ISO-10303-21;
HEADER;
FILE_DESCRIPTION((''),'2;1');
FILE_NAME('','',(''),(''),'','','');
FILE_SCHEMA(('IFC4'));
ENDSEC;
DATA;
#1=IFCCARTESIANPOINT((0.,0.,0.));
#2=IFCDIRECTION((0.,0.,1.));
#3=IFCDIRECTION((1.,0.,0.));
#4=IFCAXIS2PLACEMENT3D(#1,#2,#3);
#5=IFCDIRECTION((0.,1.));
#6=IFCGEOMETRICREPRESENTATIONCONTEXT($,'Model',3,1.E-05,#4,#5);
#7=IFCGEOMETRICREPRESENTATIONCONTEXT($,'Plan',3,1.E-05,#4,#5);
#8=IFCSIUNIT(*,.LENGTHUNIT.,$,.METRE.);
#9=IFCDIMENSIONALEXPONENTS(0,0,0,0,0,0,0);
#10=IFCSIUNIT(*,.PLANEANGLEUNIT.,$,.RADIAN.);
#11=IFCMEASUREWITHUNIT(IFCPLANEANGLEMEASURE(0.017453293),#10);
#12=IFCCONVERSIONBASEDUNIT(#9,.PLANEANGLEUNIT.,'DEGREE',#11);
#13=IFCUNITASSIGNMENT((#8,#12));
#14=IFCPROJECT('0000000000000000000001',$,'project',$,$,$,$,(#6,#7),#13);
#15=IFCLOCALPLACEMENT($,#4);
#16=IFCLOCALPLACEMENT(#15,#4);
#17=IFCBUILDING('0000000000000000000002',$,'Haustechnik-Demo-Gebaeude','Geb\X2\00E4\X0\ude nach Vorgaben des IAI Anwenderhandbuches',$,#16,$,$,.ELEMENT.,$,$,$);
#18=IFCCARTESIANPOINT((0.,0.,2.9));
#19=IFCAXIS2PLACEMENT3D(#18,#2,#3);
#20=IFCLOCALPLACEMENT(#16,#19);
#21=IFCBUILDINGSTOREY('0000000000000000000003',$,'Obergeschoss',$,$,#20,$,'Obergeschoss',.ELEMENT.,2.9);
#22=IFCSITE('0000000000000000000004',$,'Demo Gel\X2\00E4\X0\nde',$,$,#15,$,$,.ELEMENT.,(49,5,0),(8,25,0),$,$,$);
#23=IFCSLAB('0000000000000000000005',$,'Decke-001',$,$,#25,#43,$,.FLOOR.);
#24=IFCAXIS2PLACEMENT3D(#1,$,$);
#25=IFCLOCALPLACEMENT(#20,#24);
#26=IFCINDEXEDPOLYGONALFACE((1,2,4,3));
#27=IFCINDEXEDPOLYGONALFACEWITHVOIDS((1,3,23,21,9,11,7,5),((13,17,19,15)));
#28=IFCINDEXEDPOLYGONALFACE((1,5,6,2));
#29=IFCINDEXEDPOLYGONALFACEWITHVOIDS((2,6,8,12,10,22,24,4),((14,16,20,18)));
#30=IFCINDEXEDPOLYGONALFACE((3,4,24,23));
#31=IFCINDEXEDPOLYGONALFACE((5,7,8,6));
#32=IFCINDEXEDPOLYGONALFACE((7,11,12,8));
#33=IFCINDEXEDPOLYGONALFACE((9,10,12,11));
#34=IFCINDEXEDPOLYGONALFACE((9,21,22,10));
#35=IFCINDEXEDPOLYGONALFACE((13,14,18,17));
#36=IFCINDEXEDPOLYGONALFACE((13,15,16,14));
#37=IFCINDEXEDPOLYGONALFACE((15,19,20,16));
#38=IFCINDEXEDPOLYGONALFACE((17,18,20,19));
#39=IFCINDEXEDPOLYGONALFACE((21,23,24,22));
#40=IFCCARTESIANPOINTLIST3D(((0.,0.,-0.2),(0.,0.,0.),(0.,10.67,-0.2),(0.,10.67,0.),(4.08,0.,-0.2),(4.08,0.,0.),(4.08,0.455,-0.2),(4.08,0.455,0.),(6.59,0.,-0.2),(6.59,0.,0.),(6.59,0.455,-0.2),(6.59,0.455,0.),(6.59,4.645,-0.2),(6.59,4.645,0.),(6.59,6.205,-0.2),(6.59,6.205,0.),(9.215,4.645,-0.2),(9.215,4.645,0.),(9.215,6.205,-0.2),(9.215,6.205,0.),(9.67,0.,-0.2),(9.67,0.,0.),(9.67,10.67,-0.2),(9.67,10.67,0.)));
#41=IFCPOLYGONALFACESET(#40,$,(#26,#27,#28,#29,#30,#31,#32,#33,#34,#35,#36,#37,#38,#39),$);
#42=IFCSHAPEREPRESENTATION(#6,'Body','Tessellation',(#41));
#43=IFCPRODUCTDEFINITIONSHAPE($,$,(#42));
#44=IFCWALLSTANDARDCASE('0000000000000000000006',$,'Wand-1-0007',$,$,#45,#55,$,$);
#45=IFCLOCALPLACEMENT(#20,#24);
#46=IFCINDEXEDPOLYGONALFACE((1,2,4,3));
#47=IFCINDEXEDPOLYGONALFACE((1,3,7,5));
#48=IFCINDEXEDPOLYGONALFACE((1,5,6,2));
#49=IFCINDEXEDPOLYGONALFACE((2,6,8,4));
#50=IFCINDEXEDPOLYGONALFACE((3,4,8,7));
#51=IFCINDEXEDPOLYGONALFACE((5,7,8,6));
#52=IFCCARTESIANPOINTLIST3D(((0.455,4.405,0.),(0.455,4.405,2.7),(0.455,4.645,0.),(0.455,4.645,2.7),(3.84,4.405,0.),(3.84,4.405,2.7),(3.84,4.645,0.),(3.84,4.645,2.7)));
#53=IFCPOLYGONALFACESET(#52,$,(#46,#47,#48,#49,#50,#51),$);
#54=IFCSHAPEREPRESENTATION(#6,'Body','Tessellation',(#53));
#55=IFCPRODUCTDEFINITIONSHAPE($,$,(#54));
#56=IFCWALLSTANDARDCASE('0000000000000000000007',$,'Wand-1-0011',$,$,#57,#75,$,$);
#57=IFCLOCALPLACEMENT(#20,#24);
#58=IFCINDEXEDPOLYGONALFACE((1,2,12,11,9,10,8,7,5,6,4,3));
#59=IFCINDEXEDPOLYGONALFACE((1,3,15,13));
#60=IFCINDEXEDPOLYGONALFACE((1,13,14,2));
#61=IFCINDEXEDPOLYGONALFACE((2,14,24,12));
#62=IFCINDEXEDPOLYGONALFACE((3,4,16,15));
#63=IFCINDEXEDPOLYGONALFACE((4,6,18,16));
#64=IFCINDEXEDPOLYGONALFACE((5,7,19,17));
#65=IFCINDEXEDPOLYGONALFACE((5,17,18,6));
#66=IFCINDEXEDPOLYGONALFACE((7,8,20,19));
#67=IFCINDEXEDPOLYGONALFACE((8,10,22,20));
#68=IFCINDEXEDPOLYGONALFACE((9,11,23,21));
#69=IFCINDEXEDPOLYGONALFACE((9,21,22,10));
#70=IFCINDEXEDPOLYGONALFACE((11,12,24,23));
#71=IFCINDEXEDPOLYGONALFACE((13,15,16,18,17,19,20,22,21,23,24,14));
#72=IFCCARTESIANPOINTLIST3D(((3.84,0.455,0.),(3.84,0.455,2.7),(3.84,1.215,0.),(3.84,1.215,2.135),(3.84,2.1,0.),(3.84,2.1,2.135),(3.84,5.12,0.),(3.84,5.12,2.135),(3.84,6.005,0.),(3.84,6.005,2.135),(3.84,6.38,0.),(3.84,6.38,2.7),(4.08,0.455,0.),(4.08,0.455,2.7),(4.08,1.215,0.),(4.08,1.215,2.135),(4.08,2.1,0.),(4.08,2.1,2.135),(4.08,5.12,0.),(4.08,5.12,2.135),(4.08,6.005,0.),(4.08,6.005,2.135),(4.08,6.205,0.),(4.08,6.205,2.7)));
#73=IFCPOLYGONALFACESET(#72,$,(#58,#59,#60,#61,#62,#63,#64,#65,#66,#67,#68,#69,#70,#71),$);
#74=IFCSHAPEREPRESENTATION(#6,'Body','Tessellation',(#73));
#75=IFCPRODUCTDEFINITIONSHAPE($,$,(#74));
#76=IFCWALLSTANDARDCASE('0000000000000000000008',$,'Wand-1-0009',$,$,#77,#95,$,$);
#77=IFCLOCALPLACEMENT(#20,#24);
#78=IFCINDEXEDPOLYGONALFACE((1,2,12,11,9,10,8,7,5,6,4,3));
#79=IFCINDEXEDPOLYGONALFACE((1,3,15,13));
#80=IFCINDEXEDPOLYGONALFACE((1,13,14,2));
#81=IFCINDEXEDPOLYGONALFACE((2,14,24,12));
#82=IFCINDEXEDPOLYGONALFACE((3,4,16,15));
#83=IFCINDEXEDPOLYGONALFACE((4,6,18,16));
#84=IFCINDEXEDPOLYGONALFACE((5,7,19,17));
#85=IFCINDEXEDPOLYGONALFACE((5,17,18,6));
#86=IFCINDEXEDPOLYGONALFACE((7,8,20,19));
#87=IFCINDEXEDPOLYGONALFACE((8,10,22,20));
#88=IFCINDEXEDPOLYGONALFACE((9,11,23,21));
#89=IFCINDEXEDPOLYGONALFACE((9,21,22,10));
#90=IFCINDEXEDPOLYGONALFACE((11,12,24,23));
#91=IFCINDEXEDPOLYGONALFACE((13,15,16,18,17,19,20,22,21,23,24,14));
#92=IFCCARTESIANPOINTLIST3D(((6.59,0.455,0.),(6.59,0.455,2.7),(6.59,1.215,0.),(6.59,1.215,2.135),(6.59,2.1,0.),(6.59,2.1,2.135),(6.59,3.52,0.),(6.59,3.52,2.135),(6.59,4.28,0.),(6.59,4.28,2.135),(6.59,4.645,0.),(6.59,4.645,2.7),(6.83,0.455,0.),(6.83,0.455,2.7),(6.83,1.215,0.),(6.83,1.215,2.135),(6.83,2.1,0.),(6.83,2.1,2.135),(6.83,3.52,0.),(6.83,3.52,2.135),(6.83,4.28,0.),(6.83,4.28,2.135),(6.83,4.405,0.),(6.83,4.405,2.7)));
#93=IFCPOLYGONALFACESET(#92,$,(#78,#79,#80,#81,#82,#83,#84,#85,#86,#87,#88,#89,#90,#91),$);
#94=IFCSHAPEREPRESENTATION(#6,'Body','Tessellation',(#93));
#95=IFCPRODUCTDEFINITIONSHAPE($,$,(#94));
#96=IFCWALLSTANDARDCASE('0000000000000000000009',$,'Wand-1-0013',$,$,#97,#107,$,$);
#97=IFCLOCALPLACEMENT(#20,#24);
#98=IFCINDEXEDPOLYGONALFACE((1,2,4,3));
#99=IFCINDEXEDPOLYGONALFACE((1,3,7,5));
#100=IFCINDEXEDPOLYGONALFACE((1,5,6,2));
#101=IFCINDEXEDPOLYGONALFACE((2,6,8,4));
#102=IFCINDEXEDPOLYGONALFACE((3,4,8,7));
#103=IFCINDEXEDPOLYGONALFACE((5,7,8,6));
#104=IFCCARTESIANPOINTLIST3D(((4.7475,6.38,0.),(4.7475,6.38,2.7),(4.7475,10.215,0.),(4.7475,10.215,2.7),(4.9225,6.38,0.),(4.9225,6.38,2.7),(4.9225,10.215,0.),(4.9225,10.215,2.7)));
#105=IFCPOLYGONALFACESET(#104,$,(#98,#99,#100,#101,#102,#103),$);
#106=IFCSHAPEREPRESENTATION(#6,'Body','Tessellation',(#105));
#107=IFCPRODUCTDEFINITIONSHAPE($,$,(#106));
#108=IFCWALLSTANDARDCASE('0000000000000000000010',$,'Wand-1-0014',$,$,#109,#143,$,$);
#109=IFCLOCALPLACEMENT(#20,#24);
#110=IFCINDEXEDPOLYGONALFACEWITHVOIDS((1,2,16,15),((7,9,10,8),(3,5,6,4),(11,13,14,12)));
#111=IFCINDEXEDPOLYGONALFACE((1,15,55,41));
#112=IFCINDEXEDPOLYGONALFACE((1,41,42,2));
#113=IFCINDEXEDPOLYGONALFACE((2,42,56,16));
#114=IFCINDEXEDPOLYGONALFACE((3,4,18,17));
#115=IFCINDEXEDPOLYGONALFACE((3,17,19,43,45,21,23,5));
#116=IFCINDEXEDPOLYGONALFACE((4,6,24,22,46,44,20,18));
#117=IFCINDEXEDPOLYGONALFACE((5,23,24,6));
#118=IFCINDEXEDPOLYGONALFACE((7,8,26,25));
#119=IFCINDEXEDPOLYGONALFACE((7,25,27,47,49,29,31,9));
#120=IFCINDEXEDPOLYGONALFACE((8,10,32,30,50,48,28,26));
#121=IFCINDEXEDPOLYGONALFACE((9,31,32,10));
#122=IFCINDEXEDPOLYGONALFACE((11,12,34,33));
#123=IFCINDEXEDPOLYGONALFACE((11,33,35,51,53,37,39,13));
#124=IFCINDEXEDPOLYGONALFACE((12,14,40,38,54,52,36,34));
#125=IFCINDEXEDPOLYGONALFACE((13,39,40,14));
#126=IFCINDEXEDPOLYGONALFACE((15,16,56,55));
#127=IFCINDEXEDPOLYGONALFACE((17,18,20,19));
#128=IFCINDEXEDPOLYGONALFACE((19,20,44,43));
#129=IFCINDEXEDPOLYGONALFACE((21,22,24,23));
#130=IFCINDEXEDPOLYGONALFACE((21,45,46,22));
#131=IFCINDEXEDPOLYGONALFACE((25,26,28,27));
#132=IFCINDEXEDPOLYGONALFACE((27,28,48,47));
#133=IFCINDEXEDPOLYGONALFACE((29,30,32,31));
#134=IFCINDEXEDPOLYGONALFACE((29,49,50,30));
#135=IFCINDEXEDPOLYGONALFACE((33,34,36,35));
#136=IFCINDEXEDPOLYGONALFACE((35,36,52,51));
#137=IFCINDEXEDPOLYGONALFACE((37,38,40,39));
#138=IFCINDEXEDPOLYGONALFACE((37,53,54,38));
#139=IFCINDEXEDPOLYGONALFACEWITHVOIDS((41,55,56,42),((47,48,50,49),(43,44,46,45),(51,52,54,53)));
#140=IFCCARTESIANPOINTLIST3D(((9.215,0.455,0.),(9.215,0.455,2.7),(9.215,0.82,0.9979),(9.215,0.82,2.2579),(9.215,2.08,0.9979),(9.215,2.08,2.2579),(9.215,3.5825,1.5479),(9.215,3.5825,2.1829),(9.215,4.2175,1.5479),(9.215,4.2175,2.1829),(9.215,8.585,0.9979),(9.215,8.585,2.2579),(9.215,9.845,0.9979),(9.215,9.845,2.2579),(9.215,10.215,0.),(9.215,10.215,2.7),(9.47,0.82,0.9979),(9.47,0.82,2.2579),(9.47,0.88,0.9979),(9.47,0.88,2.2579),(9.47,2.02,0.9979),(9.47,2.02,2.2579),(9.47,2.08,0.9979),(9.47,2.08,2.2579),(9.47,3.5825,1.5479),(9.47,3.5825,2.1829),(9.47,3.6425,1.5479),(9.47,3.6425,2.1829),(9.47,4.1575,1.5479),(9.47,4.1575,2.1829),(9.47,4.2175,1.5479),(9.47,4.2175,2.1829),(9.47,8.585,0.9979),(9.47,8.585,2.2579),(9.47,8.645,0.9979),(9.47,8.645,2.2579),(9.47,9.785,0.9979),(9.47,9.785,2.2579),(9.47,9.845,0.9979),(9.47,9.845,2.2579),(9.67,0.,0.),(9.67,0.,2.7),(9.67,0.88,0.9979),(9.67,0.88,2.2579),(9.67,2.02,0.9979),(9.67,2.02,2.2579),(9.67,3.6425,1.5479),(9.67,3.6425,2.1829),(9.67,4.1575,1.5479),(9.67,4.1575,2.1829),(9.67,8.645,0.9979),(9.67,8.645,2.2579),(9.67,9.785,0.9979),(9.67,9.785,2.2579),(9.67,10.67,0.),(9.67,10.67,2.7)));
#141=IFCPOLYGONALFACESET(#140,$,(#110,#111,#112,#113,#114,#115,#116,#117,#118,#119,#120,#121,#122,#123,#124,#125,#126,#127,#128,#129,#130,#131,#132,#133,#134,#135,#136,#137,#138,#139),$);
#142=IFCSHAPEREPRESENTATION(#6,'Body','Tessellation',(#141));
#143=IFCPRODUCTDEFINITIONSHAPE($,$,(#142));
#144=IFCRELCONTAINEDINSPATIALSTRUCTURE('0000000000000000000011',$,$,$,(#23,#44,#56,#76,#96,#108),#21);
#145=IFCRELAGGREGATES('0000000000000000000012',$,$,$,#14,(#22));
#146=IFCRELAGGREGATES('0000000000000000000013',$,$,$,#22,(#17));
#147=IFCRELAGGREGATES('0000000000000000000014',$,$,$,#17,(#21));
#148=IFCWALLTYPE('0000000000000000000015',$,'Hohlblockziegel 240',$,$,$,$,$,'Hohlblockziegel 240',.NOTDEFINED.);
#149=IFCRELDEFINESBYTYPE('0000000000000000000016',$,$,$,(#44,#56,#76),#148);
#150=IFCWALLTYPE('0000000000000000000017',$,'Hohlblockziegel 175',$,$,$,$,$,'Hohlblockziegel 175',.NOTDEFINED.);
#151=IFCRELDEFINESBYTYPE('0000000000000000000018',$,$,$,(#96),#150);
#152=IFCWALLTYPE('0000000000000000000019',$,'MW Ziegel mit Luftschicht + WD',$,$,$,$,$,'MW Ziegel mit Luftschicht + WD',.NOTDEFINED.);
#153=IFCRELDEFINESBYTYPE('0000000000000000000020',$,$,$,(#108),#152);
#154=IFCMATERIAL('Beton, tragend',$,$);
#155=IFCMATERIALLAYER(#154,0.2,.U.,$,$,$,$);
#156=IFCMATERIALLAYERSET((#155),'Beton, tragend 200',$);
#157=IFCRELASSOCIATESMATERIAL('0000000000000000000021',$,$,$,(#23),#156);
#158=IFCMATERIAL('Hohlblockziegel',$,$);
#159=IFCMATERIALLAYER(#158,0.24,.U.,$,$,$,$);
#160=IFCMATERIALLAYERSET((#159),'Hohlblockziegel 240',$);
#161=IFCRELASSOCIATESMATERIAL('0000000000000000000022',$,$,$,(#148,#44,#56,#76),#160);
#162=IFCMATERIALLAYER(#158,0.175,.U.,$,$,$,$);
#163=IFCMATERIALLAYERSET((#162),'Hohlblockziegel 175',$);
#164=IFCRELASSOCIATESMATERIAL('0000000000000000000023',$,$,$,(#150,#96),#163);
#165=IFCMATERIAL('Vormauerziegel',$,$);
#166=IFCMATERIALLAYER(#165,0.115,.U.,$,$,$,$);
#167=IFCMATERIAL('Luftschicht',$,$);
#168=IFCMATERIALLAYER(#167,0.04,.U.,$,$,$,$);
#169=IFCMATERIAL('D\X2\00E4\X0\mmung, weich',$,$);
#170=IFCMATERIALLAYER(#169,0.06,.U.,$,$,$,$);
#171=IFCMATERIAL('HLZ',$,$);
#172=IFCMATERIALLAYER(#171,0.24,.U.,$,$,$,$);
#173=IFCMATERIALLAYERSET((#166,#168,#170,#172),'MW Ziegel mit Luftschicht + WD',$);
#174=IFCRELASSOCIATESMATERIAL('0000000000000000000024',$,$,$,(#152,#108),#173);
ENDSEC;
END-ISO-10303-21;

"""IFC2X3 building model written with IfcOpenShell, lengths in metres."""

from ifc_helpers import new_model, entity, si_unit, converted_unit, direction, frame, frame_2d, origin_with_axes, place, context, project, spatial, polyline, rectangle, outline, extrude, material, layer, layer_set, layer_usage, type_object, element, save


model = new_model("IFC2X3")

# Units and contexts
model_context = context("Model", 3, precision=1e-05, world=origin_with_axes(), true_north=direction((0.0, 1.0)))
plan_context = context("Plan", 3, precision=1e-05, world=origin_with_axes(), true_north=direction((0.0, 1.0)))
ifc_project = project(units=[si_unit("LENGTHUNIT", "METRE"), converted_unit("PLANEANGLEUNIT", "DEGREE", entity("IfcPlaneAngleMeasure", 0.017453293), si_unit("PLANEANGLEUNIT", "RADIAN"), dimensions=[0, 0, 0, 0, 0, 0, 0])], contexts=[model_context, plan_context])

# Site, building, storey
site_placement = place(None, origin_with_axes())
site = spatial("IfcSite", under=ifc_project, at=site_placement, Name="Demo Gelände", CompositionType="ELEMENT", RefLatitude=(49, 5, 0), RefLongitude=(8, 25, 0))
building_placement = place(site_placement, origin_with_axes())
building = spatial("IfcBuilding", under=site, at=building_placement, Name="Haustechnik-Demo-Gebaeude", Description="Gebäude nach Vorgaben des IAI Anwenderhandbuches", CompositionType="ELEMENT")
storey_placement = place(building_placement, frame((0.0, 0.0, 2.9), z_axis=(0.0, 0.0, 1.0), x_axis=(1.0, 0.0, 0.0)))
storey = spatial("IfcBuildingStorey", under=building, at=storey_placement, Name="Obergeschoss", LongName="Obergeschoss", CompositionType="ELEMENT", Elevation=2.9)

# Slab, opening
ifc_material_1 = material(Name="Beton, tragend")
ifc_layer_1 = layer(ifc_material_1, 0.2, ventilated="UNKNOWN")
ifc_layer_set_1 = layer_set([ifc_layer_1], Name="Beton, tragend 200")
ifc_layer_usage_1 = layer_usage(ifc_layer_set_1, "AXIS3", "NEGATIVE", 0.2)
slab_placement = place(storey_placement, frame((9.67, 10.67, -0.2), z_axis=(0.0, 0.0, 1.0), x_axis=(-1.0, 0.0, 0.0)))
slab = element("IfcSlab", 1, at=slab_placement, inside=storey, material=ifc_layer_usage_1, Name="Decke-001", PredefinedType="FLOOR", context=model_context, shape_type="SweptSolid", body=[
    extrude(outline(polyline([(0.0, 0.0), (9.67, 0.0), (9.67, 10.67), (5.59, 10.67), (5.59, 10.215), (3.08, 10.215), (3.08, 10.67), (0.0, 10.67), (0.0, 0.0)])), origin_with_axes(), (0.0, 0.0, 1.0), 0.2),
])
opening_1_placement = place(slab_placement, origin_with_axes())
element("IfcOpeningElement", 2, at=opening_1_placement, cuts=slab, context=model_context, shape_type="SweptSolid", body=[
    extrude(outline(polyline([(0.455, 4.465), (0.455, 6.025), (3.08, 6.025), (3.08, 4.465), (0.455, 4.465)])), origin_with_axes(), (0.0, 0.0, 1.0), 0.2),
])

# Wall
ifc_material_2 = material(Name="Hohlblockziegel")
ifc_layer_2 = layer(ifc_material_2, 0.24, ventilated="UNKNOWN")
ifc_layer_set_2 = layer_set([ifc_layer_2], Name="Hohlblockziegel 240")
ifc_layer_usage_2 = layer_usage(ifc_layer_set_2, "AXIS2", "NEGATIVE", 0.0)
wall_type_1 = type_object("IfcWallType", Name="Hohlblockziegel 240", ElementType="Hohlblockziegel 240", PredefinedType="NOTDEFINED", material=ifc_layer_set_2)
wall_1_placement = place(storey_placement, frame((0.0, 4.645, 0.0), z_axis=(0.0, 0.0, 1.0), x_axis=(1.0, 0.0, 0.0)))
element("IfcWallStandardCase", 3, at=wall_1_placement, inside=storey, type_object=wall_type_1, material=ifc_layer_usage_2, Name="Wand-1-0007", context=model_context, shape_type="SweptSolid", body=[
    extrude(outline(polyline([(0.455, -0.24), (3.84, -0.24), (3.84, 0.0), (0.455, 0.0), (0.455, -0.24)])), origin_with_axes(), (0.0, 0.0, 1.0), 2.7),
])

# Walls, openings
ifc_layer_usage_3 = layer_usage(ifc_layer_set_2, "AXIS2", "NEGATIVE", 0.0)
wall_2_placement = place(storey_placement, frame((3.84, 0.0, 0.0), z_axis=(0.0, 0.0, 1.0), x_axis=(0.0, 1.0, 0.0)))
wall_2 = element("IfcWallStandardCase", 4, at=wall_2_placement, inside=storey, type_object=wall_type_1, material=ifc_layer_usage_3, Name="Wand-1-0011", context=model_context, shape_type="SweptSolid", body=[
    extrude(outline(polyline([(0.455, -0.24), (6.205, -0.24), (6.38, 0.0), (0.455, 0.0), (0.455, -0.24)])), origin_with_axes(), (0.0, 0.0, 1.0), 2.7),
])
opening_2_placement = place(wall_2_placement, frame((1.6575, -0.24, 0.0), z_axis=(0.0, 0.0, 1.0), x_axis=(1.0, 0.0, 0.0)))
element("IfcOpeningElement", 5, at=opening_2_placement, cuts=wall_2, ObjectType="Opening", context=model_context, shape_type="SweptSolid", body=[
    extrude(rectangle(XDim=0.885, YDim=2.135, at=frame_2d((0.0, 1.0675), x_axis=(-1.0, 0.0))), frame((0.0, 0.0, 0.0), z_axis=(0.0, 1.0, 0.0), x_axis=(-1.0, 0.0, 0.0)), (0.0, 0.0, 1.0), 0.24),
])
opening_3_placement = place(wall_2_placement, frame((5.5625, -0.24, 0.0), z_axis=(0.0, 0.0, 1.0), x_axis=(1.0, 0.0, 0.0)))
element("IfcOpeningElement", 6, at=opening_3_placement, cuts=wall_2, ObjectType="Opening", context=model_context, shape_type="SweptSolid", body=[
    extrude(rectangle(XDim=0.885, YDim=2.135, at=frame_2d((0.0, 1.0675), x_axis=(-1.0, 0.0))), frame((0.0, 0.0, 0.0), z_axis=(0.0, 1.0, 0.0), x_axis=(-1.0, 0.0, 0.0)), (0.0, 0.0, 1.0), 0.24),
])
ifc_layer_usage_4 = layer_usage(ifc_layer_set_2, "AXIS2", "POSITIVE", 0.0)
wall_3_placement = place(storey_placement, frame((6.83, 0.0, 0.0), z_axis=(0.0, 0.0, 1.0), x_axis=(0.0, 1.0, 0.0)))
wall_3 = element("IfcWallStandardCase", 7, at=wall_3_placement, inside=storey, type_object=wall_type_1, material=ifc_layer_usage_4, Name="Wand-1-0009", context=model_context, shape_type="SweptSolid", body=[
    extrude(outline(polyline([(0.455, 0.0), (4.405, 0.0), (4.645, 0.24), (0.455, 0.24), (0.455, 0.0)])), origin_with_axes(), (0.0, 0.0, 1.0), 2.7),
])
opening_4_placement = place(wall_3_placement, frame((1.6575, 0.0, 0.0), z_axis=(0.0, 0.0, 1.0), x_axis=(1.0, 0.0, 0.0)))
element("IfcOpeningElement", 8, at=opening_4_placement, cuts=wall_3, ObjectType="Opening", context=model_context, shape_type="SweptSolid", body=[
    extrude(rectangle(XDim=0.885, YDim=2.135, at=frame_2d((0.0, 1.0675), x_axis=(-1.0, 0.0))), frame((0.0, 0.0, 0.0), z_axis=(0.0, 1.0, 0.0), x_axis=(-1.0, 0.0, 0.0)), (0.0, 0.0, 1.0), 0.24),
])
opening_5_placement = place(wall_3_placement, frame((3.9, 0.0, 0.0), z_axis=(0.0, 0.0, 1.0), x_axis=(1.0, 0.0, 0.0)))
element("IfcOpeningElement", 9, at=opening_5_placement, cuts=wall_3, ObjectType="Opening", context=model_context, shape_type="SweptSolid", body=[
    extrude(rectangle(XDim=0.76, YDim=2.135, at=frame_2d((0.0, 1.0675), x_axis=(-1.0, 0.0))), frame((0.0, 0.0, 0.0), z_axis=(0.0, 1.0, 0.0), x_axis=(-1.0, 0.0, 0.0)), (0.0, 0.0, 1.0), 0.24),
])

# Shared definitions
ifc_layer_3 = layer(ifc_material_2, 0.175, ventilated="UNKNOWN")
ifc_layer_set_3 = layer_set([ifc_layer_3], Name="Hohlblockziegel 175")
wall_type_2 = type_object("IfcWallType", Name="Hohlblockziegel 175", ElementType="Hohlblockziegel 175", PredefinedType="NOTDEFINED", material=ifc_layer_set_3)

# Wall
ifc_layer_usage_5 = layer_usage(ifc_layer_set_3, "AXIS2", "NEGATIVE", 0.0)
wall_4_placement = place(storey_placement, frame((4.7475, 6.38, 0.0), z_axis=(0.0, 0.0, 1.0), x_axis=(0.0, 1.0, 0.0)))
element("IfcWallStandardCase", 10, at=wall_4_placement, inside=storey, type_object=wall_type_2, material=ifc_layer_usage_5, Name="Wand-1-0013", context=model_context, shape_type="SweptSolid", body=[
    extrude(outline(polyline([(0.0, -0.175), (3.835, -0.175), (3.835, 0.0), (0.0, 0.0), (0.0, -0.175)])), origin_with_axes(), (0.0, 0.0, 1.0), 2.7),
])

# Wall, openings
ifc_material_3 = material(Name="Vormauerziegel")
ifc_layer_4 = layer(ifc_material_3, 0.115, ventilated="UNKNOWN")
ifc_material_4 = material(Name="Luftschicht")
ifc_layer_5 = layer(ifc_material_4, 0.04, ventilated="UNKNOWN")
ifc_material_5 = material(Name="Dämmung, weich")
ifc_layer_6 = layer(ifc_material_5, 0.06, ventilated="UNKNOWN")
ifc_material_6 = material(Name="HLZ")
ifc_layer_7 = layer(ifc_material_6, 0.24, ventilated="UNKNOWN")
ifc_layer_set_4 = layer_set([ifc_layer_4, ifc_layer_5, ifc_layer_6, ifc_layer_7], Name="MW Ziegel mit Luftschicht + WD")
ifc_layer_usage_6 = layer_usage(ifc_layer_set_4, "AXIS2", "POSITIVE", 0.0)
wall_type_3 = type_object("IfcWallType", Name="MW Ziegel mit Luftschicht + WD", ElementType="MW Ziegel mit Luftschicht + WD", PredefinedType="NOTDEFINED", material=ifc_layer_set_4)
wall_5_placement = place(storey_placement, frame((9.67, 0.0, 0.0), z_axis=(0.0, 0.0, 1.0), x_axis=(0.0, 1.0, 0.0)))
wall_5 = element("IfcWallStandardCase", 11, at=wall_5_placement, inside=storey, type_object=wall_type_3, material=ifc_layer_usage_6, Name="Wand-1-0014", context=model_context, shape_type="SweptSolid", body=[
    extrude(outline(polyline([(0.0, 0.0), (10.67, 0.0), (10.215, 0.455), (0.455, 0.455), (0.0, 0.0)])), origin_with_axes(), (0.0, 0.0, 1.0), 2.7),
])
opening_6_placement = place(wall_5_placement, frame((1.45, 0.0, 0.9979), z_axis=(0.0, 0.0, 1.0), x_axis=(1.0, 0.0, 0.0)))
element("IfcOpeningElement", 12, at=opening_6_placement, cuts=wall_5, ObjectType="Opening", context=model_context, shape_type="SweptSolid", body=[
    extrude(outline(polyline([(-0.57, 0.0), (0.57, 0.0), (0.57, 0.2), (0.63, 0.2), (0.63, 0.455), (-0.63, 0.455), (-0.63, 0.2), (-0.57, 0.2), (-0.57, 0.0)])), origin_with_axes(), (0.0, 0.0, 1.0), 1.26),
])
opening_7_placement = place(wall_5_placement, frame((9.215, 0.0, 0.9979), z_axis=(0.0, 0.0, 1.0), x_axis=(1.0, 0.0, 0.0)))
element("IfcOpeningElement", 13, at=opening_7_placement, cuts=wall_5, ObjectType="Opening", context=model_context, shape_type="SweptSolid", body=[
    extrude(outline(polyline([(-0.57, 0.0), (0.57, 0.0), (0.57, 0.2), (0.63, 0.2), (0.63, 0.455), (-0.63, 0.455), (-0.63, 0.2), (-0.57, 0.2), (-0.57, 0.0)])), origin_with_axes(), (0.0, 0.0, 1.0), 1.26),
])
opening_8_placement = place(wall_5_placement, frame((3.9, 0.0, 1.5479), z_axis=(0.0, 0.0, 1.0), x_axis=(1.0, 0.0, 0.0)))
element("IfcOpeningElement", 14, at=opening_8_placement, cuts=wall_5, ObjectType="Opening", context=model_context, shape_type="SweptSolid", body=[
    extrude(outline(polyline([(-0.2575, 0.0), (0.2575, 0.0), (0.2575, 0.2), (0.3175, 0.2), (0.3175, 0.455), (-0.3175, 0.455), (-0.3175, 0.2), (-0.2575, 0.2), (-0.2575, 0.0)])), origin_with_axes(), (0.0, 0.0, 1.0), 0.635),
])

save(model, "model.ifc")
